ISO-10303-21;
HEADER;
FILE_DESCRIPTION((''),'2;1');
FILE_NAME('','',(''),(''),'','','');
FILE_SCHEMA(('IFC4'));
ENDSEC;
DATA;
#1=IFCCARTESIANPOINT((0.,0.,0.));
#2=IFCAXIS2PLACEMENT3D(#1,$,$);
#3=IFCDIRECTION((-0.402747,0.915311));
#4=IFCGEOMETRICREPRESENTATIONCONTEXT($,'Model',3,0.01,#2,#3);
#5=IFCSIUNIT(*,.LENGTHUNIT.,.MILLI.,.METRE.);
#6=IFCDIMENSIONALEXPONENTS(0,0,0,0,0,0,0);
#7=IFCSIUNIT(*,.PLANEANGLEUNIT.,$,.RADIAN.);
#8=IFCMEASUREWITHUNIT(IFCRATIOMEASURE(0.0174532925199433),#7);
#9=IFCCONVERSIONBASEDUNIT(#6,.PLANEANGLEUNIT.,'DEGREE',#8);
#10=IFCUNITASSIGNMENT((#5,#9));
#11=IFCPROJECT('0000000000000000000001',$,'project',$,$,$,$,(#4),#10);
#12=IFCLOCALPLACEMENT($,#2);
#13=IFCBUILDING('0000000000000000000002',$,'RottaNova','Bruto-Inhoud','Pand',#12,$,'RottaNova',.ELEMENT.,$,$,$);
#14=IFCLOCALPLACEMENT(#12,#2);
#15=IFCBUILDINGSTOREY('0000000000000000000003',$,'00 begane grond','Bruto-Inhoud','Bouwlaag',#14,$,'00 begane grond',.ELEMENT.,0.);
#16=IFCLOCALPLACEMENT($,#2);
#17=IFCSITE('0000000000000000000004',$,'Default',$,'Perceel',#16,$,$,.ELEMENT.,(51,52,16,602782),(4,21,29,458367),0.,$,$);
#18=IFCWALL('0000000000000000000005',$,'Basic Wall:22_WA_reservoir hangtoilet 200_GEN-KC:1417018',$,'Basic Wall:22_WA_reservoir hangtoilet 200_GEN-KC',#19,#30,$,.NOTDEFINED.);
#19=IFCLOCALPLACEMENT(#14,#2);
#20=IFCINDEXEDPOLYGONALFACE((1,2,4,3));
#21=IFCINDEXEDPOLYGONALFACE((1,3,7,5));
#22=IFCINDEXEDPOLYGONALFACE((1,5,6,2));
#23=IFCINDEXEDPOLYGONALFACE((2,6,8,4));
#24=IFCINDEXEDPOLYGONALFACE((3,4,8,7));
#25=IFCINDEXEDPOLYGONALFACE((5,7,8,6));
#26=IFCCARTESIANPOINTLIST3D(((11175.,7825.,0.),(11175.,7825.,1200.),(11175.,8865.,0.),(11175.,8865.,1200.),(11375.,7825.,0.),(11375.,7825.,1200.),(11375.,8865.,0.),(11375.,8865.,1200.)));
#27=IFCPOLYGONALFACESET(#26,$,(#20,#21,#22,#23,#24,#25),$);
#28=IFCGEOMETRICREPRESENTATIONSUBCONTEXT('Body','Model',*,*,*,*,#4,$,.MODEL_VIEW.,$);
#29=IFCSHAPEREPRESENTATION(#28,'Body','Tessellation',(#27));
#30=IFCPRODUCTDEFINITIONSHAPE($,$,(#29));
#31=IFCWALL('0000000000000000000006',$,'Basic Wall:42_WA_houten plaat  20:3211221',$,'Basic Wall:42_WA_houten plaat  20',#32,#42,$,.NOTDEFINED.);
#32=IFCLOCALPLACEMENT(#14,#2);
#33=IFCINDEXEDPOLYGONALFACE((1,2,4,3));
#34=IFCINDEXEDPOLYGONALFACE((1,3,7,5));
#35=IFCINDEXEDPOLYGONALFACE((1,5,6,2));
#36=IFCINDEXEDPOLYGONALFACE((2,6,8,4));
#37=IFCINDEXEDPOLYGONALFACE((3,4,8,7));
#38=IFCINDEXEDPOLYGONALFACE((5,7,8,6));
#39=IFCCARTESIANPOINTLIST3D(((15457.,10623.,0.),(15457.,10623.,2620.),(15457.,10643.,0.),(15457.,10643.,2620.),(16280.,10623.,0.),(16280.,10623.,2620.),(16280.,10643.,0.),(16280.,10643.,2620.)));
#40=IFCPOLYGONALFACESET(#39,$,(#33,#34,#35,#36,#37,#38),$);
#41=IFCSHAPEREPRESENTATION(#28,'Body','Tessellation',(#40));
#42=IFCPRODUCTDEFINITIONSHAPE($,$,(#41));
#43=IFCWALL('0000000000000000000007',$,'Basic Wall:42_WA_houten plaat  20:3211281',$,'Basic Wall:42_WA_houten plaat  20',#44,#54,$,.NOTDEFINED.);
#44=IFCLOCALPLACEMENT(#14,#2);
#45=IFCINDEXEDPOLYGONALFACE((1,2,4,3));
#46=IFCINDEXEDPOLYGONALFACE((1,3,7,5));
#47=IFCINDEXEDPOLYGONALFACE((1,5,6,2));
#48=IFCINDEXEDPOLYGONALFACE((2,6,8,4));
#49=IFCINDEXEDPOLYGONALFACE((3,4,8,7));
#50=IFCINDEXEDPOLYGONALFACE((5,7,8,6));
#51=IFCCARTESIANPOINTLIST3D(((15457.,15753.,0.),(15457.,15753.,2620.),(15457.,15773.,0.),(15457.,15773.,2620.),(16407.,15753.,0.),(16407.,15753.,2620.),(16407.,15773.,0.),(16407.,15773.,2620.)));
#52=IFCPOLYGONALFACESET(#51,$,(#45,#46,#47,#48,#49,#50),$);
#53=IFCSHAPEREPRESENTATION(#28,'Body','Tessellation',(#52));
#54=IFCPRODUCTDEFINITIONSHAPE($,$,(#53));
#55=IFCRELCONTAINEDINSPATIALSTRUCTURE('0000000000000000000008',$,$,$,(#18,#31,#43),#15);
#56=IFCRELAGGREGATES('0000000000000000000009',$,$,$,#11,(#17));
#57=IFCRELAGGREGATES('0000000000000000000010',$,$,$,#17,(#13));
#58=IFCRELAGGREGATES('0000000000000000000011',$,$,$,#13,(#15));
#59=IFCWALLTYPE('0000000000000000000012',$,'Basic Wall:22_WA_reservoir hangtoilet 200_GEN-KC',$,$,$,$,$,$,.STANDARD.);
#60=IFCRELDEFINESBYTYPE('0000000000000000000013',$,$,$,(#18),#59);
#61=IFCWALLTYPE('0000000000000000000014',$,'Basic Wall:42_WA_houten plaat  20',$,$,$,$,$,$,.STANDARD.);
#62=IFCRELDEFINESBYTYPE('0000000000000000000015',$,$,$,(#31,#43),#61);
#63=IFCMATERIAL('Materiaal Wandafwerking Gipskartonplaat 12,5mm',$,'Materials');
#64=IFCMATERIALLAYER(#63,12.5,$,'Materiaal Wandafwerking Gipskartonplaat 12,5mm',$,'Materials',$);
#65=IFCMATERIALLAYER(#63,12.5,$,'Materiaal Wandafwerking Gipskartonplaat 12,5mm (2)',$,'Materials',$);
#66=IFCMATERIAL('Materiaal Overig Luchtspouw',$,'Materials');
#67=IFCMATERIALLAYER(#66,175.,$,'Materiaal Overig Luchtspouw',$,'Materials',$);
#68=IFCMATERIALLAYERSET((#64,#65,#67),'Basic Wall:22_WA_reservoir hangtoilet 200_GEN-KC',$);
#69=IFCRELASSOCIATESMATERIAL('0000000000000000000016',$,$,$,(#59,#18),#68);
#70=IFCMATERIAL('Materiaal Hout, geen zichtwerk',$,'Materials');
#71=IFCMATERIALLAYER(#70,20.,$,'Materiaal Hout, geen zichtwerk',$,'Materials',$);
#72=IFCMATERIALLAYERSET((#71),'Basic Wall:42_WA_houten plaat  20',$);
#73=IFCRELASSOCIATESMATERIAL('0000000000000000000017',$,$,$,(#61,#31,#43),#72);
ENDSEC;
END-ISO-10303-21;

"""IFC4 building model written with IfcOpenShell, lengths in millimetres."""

from ifc_helpers import new_model, entity, si_unit, converted_unit, direction, frame, frame_2d, origin, place, context, subcontext, project, spatial, rectangle, extrude, material, layer, layer_set, type_object, element, save


model = new_model("IFC4")

# Units and contexts
model_context = context("Model", 3, precision=0.01, world=origin(), true_north=direction((-0.402747, 0.915311)))
body_context = subcontext(model_context, "Body", "Model", "MODEL_VIEW")
ifc_project = project(units=[si_unit("LENGTHUNIT", "METRE", prefix="MILLI"), converted_unit("PLANEANGLEUNIT", "DEGREE", entity("IfcRatioMeasure", 0.0174532925199433), si_unit("PLANEANGLEUNIT", "RADIAN"), dimensions=[0, 0, 0, 0, 0, 0, 0])], contexts=[model_context])

# Site, building, storey
site_placement = place(None, origin())
site = spatial("IfcSite", under=ifc_project, at=site_placement, Name="Default", ObjectType="Perceel", CompositionType="ELEMENT", RefLatitude=(51, 52, 16, 602782), RefLongitude=(4, 21, 29, 458367), RefElevation=0.0)
building_placement = place(None, origin())
building = spatial("IfcBuilding", under=site, at=building_placement, Name="RottaNova", Description="Bruto-Inhoud", ObjectType="Pand", LongName="RottaNova", CompositionType="ELEMENT")
storey_placement = place(building_placement, origin())
storey = spatial("IfcBuildingStorey", under=building, at=storey_placement, Name="00 begane grond", Description="Bruto-Inhoud", ObjectType="Bouwlaag", LongName="00 begane grond", CompositionType="ELEMENT", Elevation=0.0)

# Walls
ifc_material_1 = material(Name="Materiaal Wandafwerking Gipskartonplaat 12,5mm", Category="Materials")
ifc_layer_1 = layer(ifc_material_1, 12.5, Name="Materiaal Wandafwerking Gipskartonplaat 12,5mm", Category="Materials")
ifc_layer_2 = layer(ifc_material_1, 12.5, Name="Materiaal Wandafwerking Gipskartonplaat 12,5mm (2)", Category="Materials")
ifc_material_2 = material(Name="Materiaal Overig Luchtspouw", Category="Materials")
ifc_layer_3 = layer(ifc_material_2, 175.0, Name="Materiaal Overig Luchtspouw", Category="Materials")
ifc_layer_set_1 = layer_set([ifc_layer_1, ifc_layer_2, ifc_layer_3], Name="Basic Wall:22_WA_reservoir hangtoilet 200_GEN-KC")
wall_type_1 = type_object("IfcWallType", Name="Basic Wall:22_WA_reservoir hangtoilet 200_GEN-KC", PredefinedType="STANDARD", material=ifc_layer_set_1)
wall_1_placement = place(storey_placement, frame((11275.0, 8865.0, 0.0), z_axis=(0.0, 0.0, 1.0), x_axis=(0.0, -1.0, 0.0)))
element("IfcWall", 1, at=wall_1_placement, inside=storey, type_object=wall_type_1, material=ifc_layer_set_1, Name="Basic Wall:22_WA_reservoir hangtoilet 200_GEN-KC:1417018", ObjectType="Basic Wall:22_WA_reservoir hangtoilet 200_GEN-KC", PredefinedType="NOTDEFINED", context=body_context, shape_type="SweptSolid", body=[
    extrude(rectangle(XDim=1040.0, YDim=200.0, at=frame_2d((520.0, 0.0), x_axis=(-1.0, 0.0))), origin(), (0.0, 0.0, 1.0), 1200.0),
])
ifc_material_3 = material(Name="Materiaal Hout, geen zichtwerk", Category="Materials")
ifc_layer_4 = layer(ifc_material_3, 20.0, Name="Materiaal Hout, geen zichtwerk", Category="Materials")
ifc_layer_set_2 = layer_set([ifc_layer_4], Name="Basic Wall:42_WA_houten plaat  20")
wall_type_2 = type_object("IfcWallType", Name="Basic Wall:42_WA_houten plaat  20", PredefinedType="STANDARD", material=ifc_layer_set_2)
wall_2_placement = place(storey_placement, frame((16280.0, 10633.0, 0.0), z_axis=(0.0, 0.0, 1.0), x_axis=(-1.0, 0.0, 0.0)))
element("IfcWall", 2, at=wall_2_placement, inside=storey, type_object=wall_type_2, material=ifc_layer_set_2, Name="Basic Wall:42_WA_houten plaat  20:3211221", ObjectType="Basic Wall:42_WA_houten plaat  20", PredefinedType="NOTDEFINED", context=body_context, shape_type="SweptSolid", body=[
    extrude(rectangle(XDim=823.0, YDim=20.0, at=frame_2d((411.5, 0.0), x_axis=(-1.0, 0.0))), origin(), (0.0, 0.0, 1.0), 2620.0),
])
wall_3_placement = place(storey_placement, frame((16407.0, 15763.0, 0.0), z_axis=(0.0, 0.0, 1.0), x_axis=(-1.0, 0.0, 0.0)))
element("IfcWall", 3, at=wall_3_placement, inside=storey, type_object=wall_type_2, material=ifc_layer_set_2, Name="Basic Wall:42_WA_houten plaat  20:3211281", ObjectType="Basic Wall:42_WA_houten plaat  20", PredefinedType="NOTDEFINED", context=body_context, shape_type="SweptSolid", body=[
    extrude(rectangle(XDim=950.0, YDim=20.0, at=frame_2d((475.0, 0.0), x_axis=(-1.0, 0.0))), origin(), (0.0, 0.0, 1.0), 2620.0),
])

save(model, "model.ifc")
